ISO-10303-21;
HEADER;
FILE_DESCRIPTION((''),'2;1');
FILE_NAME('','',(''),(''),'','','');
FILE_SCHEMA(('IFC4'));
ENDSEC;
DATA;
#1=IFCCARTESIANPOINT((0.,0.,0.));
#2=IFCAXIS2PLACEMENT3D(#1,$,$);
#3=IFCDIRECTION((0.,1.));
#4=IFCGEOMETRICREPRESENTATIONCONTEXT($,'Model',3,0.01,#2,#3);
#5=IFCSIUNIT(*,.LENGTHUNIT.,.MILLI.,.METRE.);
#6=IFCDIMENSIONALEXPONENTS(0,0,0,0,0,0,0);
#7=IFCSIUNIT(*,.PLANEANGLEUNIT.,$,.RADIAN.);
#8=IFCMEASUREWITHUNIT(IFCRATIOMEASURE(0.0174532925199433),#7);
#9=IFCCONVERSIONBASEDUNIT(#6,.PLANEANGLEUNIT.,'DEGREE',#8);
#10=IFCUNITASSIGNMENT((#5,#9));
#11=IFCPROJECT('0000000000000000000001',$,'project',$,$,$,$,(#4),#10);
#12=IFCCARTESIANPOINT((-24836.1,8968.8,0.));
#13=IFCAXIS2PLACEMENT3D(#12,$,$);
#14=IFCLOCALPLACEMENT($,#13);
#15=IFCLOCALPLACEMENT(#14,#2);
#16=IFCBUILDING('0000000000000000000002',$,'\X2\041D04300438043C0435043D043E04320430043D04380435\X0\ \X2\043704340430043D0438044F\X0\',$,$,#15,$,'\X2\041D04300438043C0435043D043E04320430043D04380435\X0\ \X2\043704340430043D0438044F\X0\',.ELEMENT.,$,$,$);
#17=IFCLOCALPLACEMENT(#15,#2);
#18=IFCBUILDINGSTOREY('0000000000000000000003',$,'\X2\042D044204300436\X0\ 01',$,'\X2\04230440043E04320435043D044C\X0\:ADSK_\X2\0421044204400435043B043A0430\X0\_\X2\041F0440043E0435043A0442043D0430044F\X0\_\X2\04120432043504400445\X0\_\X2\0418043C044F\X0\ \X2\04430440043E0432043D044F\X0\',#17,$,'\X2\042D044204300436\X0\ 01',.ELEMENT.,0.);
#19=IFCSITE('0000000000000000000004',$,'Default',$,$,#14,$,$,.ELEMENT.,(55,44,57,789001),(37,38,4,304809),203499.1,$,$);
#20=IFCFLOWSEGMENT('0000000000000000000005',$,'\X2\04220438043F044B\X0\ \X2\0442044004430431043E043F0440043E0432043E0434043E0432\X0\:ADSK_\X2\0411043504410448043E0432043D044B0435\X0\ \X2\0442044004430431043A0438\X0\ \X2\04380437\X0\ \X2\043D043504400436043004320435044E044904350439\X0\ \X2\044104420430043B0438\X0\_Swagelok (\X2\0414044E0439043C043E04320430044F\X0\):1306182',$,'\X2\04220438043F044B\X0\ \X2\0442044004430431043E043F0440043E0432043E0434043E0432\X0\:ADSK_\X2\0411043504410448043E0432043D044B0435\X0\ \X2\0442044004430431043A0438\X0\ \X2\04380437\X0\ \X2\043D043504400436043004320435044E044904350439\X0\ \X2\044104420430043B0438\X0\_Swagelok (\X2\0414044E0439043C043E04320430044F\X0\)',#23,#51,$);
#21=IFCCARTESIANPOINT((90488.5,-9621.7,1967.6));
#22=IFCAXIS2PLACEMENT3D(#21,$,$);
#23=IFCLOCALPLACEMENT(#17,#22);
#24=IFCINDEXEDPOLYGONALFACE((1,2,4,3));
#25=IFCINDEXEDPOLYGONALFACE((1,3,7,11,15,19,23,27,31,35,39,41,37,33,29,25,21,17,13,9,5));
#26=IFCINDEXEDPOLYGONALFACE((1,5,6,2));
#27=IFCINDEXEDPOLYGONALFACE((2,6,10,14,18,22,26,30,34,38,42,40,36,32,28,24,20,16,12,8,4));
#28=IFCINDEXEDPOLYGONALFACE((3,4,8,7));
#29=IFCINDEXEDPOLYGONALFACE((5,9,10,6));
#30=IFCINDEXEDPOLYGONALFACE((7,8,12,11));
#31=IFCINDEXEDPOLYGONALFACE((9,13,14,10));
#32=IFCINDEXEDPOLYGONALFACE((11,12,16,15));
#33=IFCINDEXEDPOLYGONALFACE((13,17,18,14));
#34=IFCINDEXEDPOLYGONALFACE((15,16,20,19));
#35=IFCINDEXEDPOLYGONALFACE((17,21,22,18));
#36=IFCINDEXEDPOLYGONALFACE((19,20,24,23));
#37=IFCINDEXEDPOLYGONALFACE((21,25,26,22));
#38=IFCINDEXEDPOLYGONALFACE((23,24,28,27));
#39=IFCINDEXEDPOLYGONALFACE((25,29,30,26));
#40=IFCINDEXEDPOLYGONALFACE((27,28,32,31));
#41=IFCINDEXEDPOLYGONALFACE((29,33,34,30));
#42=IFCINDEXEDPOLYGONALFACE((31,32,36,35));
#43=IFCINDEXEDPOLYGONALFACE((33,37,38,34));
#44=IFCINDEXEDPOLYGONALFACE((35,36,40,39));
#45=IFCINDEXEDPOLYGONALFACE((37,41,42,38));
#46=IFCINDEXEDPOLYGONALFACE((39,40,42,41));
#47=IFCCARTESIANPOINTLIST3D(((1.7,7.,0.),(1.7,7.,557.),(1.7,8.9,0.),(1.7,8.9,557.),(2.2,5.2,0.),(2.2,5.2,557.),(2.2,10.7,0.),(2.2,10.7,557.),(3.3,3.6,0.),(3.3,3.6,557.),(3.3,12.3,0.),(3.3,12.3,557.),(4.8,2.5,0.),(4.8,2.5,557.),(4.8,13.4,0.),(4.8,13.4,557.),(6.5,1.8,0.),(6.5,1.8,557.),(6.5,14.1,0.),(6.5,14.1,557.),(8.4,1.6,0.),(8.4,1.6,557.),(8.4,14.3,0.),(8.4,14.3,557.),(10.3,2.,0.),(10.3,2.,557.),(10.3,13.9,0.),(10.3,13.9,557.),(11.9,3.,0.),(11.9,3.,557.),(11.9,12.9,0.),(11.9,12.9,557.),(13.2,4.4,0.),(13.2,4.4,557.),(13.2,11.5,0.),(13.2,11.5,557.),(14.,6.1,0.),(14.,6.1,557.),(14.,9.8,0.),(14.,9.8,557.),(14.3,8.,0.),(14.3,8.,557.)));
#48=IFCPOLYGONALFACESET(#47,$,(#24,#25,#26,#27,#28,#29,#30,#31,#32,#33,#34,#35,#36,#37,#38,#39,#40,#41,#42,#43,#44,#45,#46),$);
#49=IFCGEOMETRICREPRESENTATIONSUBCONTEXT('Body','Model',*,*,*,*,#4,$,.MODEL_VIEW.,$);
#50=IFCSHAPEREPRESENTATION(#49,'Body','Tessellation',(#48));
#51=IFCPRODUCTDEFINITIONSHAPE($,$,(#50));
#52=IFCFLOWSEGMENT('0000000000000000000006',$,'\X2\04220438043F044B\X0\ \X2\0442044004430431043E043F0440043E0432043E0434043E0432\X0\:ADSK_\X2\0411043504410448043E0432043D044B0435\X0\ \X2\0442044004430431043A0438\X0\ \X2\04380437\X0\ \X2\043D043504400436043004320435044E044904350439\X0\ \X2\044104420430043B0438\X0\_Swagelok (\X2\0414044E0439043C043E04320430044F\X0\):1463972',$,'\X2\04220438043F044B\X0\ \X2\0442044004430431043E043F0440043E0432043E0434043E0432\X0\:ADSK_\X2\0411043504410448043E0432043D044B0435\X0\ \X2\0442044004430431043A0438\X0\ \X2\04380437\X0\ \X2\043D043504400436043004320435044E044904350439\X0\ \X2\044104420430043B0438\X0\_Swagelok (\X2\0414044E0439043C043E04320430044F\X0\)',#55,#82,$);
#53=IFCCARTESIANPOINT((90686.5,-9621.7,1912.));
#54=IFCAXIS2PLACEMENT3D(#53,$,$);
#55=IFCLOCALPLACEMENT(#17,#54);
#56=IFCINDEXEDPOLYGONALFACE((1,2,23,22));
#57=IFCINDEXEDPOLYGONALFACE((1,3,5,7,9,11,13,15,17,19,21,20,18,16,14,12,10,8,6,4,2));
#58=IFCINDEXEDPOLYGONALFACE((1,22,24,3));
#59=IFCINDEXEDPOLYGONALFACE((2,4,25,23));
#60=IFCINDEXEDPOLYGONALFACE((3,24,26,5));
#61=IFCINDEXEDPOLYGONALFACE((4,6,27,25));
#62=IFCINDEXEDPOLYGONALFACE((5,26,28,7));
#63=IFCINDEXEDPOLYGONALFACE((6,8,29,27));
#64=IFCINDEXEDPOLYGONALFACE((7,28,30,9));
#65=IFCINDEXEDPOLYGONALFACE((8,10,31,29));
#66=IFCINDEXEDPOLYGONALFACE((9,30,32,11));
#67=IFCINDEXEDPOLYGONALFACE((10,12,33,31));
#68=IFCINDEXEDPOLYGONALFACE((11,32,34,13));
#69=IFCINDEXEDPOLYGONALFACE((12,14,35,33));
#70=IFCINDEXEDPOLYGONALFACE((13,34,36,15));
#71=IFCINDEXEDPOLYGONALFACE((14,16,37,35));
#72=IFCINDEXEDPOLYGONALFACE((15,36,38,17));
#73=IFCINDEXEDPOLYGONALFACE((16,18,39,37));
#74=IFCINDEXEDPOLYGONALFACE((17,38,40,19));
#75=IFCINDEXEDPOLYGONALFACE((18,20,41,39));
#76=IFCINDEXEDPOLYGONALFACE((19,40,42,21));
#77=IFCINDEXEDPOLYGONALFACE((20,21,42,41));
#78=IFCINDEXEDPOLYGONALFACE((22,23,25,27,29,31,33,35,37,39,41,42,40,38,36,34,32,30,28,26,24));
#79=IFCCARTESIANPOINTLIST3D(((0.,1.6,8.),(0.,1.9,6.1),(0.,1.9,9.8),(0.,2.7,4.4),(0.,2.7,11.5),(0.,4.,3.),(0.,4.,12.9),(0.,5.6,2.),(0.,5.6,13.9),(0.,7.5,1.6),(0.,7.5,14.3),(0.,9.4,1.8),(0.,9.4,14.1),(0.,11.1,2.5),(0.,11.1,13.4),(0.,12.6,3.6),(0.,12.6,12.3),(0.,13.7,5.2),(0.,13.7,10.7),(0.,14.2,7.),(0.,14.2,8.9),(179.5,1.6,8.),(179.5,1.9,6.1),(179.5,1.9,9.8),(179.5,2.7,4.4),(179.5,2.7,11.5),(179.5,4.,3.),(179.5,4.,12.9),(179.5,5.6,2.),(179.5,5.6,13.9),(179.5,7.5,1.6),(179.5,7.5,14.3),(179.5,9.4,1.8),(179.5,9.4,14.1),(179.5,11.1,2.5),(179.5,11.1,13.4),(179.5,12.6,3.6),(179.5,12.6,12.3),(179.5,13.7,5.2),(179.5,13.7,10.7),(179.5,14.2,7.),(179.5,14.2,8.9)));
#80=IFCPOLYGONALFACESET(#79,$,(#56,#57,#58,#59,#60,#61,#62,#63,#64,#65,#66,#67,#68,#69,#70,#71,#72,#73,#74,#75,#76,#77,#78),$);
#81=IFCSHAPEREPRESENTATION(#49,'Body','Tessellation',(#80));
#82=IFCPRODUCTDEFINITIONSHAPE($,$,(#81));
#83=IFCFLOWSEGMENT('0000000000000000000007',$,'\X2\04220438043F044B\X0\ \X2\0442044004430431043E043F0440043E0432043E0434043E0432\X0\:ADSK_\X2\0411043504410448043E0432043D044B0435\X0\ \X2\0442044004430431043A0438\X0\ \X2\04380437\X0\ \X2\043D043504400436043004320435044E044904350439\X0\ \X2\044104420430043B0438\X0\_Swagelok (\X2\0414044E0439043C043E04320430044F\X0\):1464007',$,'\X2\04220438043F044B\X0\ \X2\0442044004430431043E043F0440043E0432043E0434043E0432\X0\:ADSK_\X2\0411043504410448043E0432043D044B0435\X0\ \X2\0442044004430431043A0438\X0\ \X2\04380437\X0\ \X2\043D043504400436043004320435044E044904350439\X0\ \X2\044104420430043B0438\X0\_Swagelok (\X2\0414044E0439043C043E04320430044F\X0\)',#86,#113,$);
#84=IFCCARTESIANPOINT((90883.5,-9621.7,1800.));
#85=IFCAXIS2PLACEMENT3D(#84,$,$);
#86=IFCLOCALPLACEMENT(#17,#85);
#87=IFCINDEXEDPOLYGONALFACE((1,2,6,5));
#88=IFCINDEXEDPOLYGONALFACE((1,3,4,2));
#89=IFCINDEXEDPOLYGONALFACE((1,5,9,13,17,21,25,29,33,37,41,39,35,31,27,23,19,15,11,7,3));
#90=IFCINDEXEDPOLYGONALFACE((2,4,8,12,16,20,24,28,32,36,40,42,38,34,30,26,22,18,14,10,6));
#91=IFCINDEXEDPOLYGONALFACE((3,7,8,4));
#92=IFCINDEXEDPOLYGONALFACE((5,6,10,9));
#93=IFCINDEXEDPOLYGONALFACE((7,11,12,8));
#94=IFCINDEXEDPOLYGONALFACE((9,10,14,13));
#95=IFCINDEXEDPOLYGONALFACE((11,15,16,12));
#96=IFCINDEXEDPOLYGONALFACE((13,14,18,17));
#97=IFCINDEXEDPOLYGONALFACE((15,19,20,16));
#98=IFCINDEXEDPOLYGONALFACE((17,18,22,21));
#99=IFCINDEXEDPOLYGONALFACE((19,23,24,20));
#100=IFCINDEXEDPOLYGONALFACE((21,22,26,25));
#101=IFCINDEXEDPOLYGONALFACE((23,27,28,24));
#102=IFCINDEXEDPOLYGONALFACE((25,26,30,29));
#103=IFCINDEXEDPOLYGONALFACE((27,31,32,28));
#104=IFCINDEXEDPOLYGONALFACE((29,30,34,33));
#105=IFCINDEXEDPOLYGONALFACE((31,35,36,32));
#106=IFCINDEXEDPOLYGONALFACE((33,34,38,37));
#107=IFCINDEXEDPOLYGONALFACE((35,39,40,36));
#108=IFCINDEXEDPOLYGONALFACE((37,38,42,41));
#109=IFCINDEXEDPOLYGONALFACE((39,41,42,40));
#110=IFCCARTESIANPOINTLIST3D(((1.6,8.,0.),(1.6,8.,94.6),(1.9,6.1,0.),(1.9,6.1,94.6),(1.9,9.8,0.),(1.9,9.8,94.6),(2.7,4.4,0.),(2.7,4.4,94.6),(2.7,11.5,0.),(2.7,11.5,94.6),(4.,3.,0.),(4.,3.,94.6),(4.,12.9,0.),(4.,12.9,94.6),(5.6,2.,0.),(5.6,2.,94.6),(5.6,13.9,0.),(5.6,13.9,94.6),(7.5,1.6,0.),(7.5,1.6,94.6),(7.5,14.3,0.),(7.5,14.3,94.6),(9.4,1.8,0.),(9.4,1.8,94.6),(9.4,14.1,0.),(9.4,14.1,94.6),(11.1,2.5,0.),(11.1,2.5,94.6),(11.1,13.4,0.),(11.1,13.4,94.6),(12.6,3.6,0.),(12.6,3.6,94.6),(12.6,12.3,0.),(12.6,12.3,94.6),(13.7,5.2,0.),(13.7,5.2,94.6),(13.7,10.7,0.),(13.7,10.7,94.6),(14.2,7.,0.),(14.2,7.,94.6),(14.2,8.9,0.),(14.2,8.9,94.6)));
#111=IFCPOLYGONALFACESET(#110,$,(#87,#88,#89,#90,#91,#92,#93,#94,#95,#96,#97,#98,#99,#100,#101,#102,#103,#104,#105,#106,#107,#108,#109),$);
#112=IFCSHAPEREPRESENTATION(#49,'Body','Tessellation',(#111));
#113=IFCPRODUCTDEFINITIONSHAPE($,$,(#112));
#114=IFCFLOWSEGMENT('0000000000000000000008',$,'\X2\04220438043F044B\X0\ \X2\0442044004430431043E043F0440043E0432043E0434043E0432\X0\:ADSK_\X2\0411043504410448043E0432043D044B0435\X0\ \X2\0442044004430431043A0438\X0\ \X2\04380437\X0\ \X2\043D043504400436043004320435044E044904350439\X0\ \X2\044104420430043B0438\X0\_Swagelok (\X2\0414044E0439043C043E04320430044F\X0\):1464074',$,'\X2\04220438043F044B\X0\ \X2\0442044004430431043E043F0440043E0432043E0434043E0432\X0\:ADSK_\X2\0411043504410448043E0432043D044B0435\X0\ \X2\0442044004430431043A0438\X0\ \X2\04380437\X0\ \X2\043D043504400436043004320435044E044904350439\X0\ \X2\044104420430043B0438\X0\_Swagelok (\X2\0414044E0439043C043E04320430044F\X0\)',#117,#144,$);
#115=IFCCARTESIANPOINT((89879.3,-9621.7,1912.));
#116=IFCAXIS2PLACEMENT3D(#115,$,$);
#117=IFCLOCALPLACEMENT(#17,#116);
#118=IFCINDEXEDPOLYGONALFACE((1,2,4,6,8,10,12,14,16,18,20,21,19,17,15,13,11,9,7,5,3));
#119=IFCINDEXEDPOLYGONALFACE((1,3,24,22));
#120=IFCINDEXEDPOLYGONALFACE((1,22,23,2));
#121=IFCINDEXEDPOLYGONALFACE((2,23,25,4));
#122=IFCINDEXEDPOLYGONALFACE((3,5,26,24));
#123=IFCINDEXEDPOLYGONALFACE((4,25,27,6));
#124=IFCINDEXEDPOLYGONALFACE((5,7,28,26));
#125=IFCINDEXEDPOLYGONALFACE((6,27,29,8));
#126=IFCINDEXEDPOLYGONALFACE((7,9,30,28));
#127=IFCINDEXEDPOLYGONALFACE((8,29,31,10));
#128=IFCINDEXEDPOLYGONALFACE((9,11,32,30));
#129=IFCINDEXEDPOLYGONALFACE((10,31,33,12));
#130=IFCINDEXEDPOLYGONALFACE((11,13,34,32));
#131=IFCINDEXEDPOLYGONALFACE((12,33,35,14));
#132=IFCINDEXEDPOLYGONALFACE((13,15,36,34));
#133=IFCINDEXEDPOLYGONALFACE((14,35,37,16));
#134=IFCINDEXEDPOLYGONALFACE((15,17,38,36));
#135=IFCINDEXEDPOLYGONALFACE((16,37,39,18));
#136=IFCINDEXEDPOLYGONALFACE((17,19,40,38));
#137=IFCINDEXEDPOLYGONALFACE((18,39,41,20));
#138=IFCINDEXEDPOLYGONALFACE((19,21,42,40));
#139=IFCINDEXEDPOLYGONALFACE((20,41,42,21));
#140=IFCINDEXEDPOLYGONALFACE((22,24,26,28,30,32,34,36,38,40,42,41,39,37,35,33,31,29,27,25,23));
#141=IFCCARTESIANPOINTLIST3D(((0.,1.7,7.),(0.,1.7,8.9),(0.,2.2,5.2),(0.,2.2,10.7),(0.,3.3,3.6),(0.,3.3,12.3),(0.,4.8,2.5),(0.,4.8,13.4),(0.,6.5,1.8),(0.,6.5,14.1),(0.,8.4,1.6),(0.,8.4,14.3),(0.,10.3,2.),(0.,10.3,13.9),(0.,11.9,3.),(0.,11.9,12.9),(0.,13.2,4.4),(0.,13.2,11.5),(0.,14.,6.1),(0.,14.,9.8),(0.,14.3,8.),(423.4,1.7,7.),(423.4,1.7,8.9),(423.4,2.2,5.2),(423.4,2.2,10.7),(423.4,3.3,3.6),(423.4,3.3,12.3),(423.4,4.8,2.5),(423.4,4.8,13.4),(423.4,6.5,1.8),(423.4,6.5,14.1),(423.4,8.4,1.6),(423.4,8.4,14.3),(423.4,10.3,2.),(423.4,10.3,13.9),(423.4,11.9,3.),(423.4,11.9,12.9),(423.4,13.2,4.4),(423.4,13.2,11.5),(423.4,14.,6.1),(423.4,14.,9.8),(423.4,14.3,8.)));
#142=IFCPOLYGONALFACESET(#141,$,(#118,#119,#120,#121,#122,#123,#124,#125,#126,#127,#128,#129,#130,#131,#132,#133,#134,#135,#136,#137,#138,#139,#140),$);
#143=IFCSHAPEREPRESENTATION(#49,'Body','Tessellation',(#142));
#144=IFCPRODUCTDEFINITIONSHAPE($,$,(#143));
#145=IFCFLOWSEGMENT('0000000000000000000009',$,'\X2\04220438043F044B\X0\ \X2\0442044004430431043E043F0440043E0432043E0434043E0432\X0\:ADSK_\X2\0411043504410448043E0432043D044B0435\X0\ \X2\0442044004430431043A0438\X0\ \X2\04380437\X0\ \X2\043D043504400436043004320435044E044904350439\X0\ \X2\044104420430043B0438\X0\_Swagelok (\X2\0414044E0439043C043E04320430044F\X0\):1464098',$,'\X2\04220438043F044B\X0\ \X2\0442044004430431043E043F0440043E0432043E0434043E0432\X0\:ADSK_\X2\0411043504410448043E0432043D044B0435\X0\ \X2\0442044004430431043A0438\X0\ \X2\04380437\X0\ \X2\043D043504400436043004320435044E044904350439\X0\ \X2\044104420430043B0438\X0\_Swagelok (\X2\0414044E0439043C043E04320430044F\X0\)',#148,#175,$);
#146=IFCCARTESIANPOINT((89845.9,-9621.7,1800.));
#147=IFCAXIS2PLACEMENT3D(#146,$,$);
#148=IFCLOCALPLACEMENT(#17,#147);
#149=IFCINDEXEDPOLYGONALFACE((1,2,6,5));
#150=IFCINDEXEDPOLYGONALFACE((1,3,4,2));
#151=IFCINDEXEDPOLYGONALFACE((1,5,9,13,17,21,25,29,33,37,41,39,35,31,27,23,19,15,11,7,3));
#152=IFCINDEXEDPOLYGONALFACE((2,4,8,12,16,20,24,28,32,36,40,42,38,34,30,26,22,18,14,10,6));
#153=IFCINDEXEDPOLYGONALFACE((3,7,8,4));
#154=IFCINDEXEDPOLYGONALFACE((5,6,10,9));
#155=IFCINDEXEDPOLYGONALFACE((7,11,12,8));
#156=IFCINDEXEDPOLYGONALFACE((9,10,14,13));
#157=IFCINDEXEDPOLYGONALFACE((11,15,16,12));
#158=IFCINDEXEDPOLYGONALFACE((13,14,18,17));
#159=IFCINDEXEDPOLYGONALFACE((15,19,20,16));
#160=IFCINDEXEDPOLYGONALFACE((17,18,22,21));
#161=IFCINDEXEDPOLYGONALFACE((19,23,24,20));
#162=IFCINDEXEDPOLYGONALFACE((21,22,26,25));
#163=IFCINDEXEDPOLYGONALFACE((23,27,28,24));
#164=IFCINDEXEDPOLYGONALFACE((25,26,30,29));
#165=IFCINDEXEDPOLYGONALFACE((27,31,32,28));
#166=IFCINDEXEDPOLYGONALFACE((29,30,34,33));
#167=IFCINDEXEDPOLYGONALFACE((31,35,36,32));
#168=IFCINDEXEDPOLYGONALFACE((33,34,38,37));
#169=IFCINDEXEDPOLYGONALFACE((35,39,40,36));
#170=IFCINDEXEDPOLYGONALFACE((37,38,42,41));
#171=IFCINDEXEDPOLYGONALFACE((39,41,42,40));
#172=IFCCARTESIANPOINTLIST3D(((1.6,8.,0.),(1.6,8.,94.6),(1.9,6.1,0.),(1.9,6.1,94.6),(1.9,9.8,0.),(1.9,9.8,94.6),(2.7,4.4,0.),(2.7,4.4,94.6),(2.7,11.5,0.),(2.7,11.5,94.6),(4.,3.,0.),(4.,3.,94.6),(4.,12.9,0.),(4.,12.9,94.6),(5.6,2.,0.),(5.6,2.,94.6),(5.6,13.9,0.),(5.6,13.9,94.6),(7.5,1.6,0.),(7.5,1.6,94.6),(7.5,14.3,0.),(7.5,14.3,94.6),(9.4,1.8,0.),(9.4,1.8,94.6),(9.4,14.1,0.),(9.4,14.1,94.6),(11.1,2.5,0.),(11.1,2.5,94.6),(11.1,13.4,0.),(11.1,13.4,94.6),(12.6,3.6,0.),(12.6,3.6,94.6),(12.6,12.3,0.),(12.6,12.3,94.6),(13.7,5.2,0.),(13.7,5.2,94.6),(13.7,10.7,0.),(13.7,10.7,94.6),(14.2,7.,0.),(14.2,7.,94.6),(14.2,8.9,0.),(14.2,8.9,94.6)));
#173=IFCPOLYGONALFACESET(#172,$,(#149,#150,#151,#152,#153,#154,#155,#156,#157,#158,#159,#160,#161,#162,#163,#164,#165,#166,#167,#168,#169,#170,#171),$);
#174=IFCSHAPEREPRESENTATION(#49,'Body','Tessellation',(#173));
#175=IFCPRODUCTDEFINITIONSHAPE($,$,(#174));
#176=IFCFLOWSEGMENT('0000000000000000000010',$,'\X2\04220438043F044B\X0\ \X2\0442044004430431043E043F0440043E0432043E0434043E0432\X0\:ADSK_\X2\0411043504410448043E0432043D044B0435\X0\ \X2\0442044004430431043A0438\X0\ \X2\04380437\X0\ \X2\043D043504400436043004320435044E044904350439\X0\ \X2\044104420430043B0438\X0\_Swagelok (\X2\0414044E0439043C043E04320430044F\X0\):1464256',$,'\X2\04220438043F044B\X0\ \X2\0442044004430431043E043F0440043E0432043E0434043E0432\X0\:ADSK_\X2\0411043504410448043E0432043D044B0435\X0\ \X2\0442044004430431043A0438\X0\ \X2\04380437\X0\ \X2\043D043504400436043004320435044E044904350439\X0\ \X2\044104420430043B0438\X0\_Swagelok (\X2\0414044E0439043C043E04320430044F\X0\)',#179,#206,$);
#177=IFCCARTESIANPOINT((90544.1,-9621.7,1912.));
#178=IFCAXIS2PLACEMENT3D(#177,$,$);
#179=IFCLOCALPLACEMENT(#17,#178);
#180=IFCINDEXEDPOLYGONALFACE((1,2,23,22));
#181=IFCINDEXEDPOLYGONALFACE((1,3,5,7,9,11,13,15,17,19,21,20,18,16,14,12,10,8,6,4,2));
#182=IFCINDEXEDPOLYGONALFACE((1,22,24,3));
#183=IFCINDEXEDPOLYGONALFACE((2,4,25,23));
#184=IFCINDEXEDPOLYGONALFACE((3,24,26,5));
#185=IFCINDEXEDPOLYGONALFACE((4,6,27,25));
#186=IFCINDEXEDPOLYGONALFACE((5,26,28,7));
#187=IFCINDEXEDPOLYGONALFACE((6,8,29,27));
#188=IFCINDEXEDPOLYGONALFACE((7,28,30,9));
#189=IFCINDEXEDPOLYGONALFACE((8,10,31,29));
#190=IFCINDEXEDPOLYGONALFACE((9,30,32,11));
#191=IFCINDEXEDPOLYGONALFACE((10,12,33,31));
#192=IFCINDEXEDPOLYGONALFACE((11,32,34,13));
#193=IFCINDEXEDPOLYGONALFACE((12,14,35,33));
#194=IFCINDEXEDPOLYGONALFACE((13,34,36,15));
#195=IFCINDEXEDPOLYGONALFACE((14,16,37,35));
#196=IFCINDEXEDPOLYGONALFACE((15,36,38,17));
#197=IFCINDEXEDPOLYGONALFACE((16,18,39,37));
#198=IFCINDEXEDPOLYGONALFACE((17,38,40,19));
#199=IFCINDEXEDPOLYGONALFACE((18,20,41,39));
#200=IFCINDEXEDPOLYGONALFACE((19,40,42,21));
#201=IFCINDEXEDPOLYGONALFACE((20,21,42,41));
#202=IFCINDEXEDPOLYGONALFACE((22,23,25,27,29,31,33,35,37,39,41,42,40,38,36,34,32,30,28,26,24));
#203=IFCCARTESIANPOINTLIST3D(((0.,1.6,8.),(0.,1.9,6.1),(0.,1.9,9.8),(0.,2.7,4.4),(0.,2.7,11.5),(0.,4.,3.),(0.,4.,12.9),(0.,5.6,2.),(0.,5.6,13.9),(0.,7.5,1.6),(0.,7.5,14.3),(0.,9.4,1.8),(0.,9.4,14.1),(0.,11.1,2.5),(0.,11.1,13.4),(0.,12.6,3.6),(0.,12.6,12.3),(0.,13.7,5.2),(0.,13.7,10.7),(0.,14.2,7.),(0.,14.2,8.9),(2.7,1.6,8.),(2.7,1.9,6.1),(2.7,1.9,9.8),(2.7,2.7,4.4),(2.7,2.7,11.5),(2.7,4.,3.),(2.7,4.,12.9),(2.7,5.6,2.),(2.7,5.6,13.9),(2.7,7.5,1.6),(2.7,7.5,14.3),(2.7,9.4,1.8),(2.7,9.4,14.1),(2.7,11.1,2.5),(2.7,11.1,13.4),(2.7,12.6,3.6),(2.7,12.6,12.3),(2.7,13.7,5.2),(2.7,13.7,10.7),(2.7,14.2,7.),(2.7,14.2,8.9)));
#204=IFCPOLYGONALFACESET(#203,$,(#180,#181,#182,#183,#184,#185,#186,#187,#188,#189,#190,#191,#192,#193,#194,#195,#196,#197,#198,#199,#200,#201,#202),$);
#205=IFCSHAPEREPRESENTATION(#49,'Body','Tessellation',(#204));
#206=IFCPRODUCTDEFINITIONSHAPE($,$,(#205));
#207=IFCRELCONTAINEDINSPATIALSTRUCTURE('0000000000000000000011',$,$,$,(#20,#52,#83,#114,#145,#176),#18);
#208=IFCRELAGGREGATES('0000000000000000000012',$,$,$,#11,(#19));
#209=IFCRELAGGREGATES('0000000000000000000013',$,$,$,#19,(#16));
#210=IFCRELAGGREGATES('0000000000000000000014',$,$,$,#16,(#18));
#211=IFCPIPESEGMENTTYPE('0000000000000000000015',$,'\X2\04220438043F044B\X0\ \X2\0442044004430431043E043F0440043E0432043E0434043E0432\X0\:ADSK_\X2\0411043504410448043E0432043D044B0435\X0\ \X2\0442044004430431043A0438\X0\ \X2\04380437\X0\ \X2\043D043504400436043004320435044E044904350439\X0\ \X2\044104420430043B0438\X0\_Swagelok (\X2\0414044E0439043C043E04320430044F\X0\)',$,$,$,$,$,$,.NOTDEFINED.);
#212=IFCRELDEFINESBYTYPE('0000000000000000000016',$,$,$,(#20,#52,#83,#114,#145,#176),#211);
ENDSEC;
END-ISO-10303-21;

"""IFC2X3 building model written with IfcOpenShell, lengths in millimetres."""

from ifc_helpers import new_model, entity, si_unit, converted_unit, direction, frame, origin, origin_2d_with_axis, place, context, subcontext, project, spatial, circle, extrude, type_object, element, save


model = new_model("IFC2X3")

# Units and contexts
model_context = context("Model", 3, precision=0.01, world=origin(), true_north=direction((0.0, 1.0)))
body_context = subcontext(model_context, "Body", "Model", "MODEL_VIEW")
ifc_project = project(units=[si_unit("LENGTHUNIT", "METRE", prefix="MILLI"), converted_unit("PLANEANGLEUNIT", "DEGREE", entity("IfcRatioMeasure", 0.0174532925199433), si_unit("PLANEANGLEUNIT", "RADIAN"), dimensions=[0, 0, 0, 0, 0, 0, 0])], contexts=[model_context])

# Site, building, storey
site_placement = place(None, frame((-24836.1, 8968.8, 0.0)))
site = spatial("IfcSite", under=ifc_project, at=site_placement, Name="Default", CompositionType="ELEMENT", RefLatitude=(55, 44, 57, 789001), RefLongitude=(37, 38, 4, 304809), RefElevation=203499.1)
building_placement = place(site_placement, origin())
building = spatial("IfcBuilding", under=site, at=building_placement, Name="Наименование здания", LongName="Наименование здания", CompositionType="ELEMENT")
storey_placement = place(building_placement, origin())
storey = spatial("IfcBuildingStorey", under=building, at=storey_placement, Name="Этаж 01", ObjectType="Уровень:ADSK_Стрелка_Проектная_Вверх_Имя уровня", LongName="Этаж 01", CompositionType="ELEMENT", Elevation=0.0)

# Flow segments
pipe_segment_type_1 = type_object("IfcPipeSegmentType", Name="Типы трубопроводов:ADSK_Бесшовные трубки из нержавеющей стали_Swagelok (Дюймовая)", PredefinedType="NOTDEFINED")
flow_segment_1_placement = place(storey_placement, frame((90488.5, -9621.7, 1967.6)))
element("IfcFlowSegment", 1, at=flow_segment_1_placement, inside=storey, type_object=pipe_segment_type_1, Name="Типы трубопроводов:ADSK_Бесшовные трубки из нержавеющей стали_Swagelok (Дюймовая):1306182", ObjectType="Типы трубопроводов:ADSK_Бесшовные трубки из нержавеющей стали_Swagelok (Дюймовая)", context=body_context, shape_type="SweptSolid", body=[
    extrude(circle(Radius=6.3, at=origin_2d_with_axis()), frame((8.0, 8.0, 0.0)), (0.0, 0.0, 1.0), 557.0),
])
flow_segment_2_placement = place(storey_placement, frame((90686.5, -9621.7, 1912.0)))
element("IfcFlowSegment", 2, at=flow_segment_2_placement, inside=storey, type_object=pipe_segment_type_1, Name="Типы трубопроводов:ADSK_Бесшовные трубки из нержавеющей стали_Swagelok (Дюймовая):1463972", ObjectType="Типы трубопроводов:ADSK_Бесшовные трубки из нержавеющей стали_Swagelok (Дюймовая)", context=body_context, shape_type="SweptSolid", body=[
    extrude(circle(Radius=6.3, at=origin_2d_with_axis()), frame((0.0, 8.0, 8.0), z_axis=(1.0, 0.0, 0.0), x_axis=(0.0, -1.0, 0.0)), (0.0, 0.0, 1.0), 179.5),
])
flow_segment_3_placement = place(storey_placement, frame((90883.5, -9621.7, 1800.0)))
element("IfcFlowSegment", 3, at=flow_segment_3_placement, inside=storey, type_object=pipe_segment_type_1, Name="Типы трубопроводов:ADSK_Бесшовные трубки из нержавеющей стали_Swagelok (Дюймовая):1464007", ObjectType="Типы трубопроводов:ADSK_Бесшовные трубки из нержавеющей стали_Swagelok (Дюймовая)", context=body_context, shape_type="SweptSolid", body=[
    extrude(circle(Radius=6.3, at=origin_2d_with_axis()), frame((8.0, 8.0, 0.0), z_axis=(0.0, 0.0, 1.0), x_axis=(-1.0, 0.0, 0.0)), (0.0, 0.0, 1.0), 94.6),
])
flow_segment_4_placement = place(storey_placement, frame((89879.3, -9621.7, 1912.0)))
element("IfcFlowSegment", 4, at=flow_segment_4_placement, inside=storey, type_object=pipe_segment_type_1, Name="Типы трубопроводов:ADSK_Бесшовные трубки из нержавеющей стали_Swagelok (Дюймовая):1464074", ObjectType="Типы трубопроводов:ADSK_Бесшовные трубки из нержавеющей стали_Swagelok (Дюймовая)", context=body_context, shape_type="SweptSolid", body=[
    extrude(circle(Radius=6.3, at=origin_2d_with_axis()), frame((0.0, 8.0, 8.0), z_axis=(1.0, 0.0, 0.0), x_axis=(0.0, 1.0, 0.0)), (0.0, 0.0, 1.0), 423.4),
])
flow_segment_5_placement = place(storey_placement, frame((89845.9, -9621.7, 1800.0)))
element("IfcFlowSegment", 5, at=flow_segment_5_placement, inside=storey, type_object=pipe_segment_type_1, Name="Типы трубопроводов:ADSK_Бесшовные трубки из нержавеющей стали_Swagelok (Дюймовая):1464098", ObjectType="Типы трубопроводов:ADSK_Бесшовные трубки из нержавеющей стали_Swagelok (Дюймовая)", context=body_context, shape_type="SweptSolid", body=[
    extrude(circle(Radius=6.3, at=origin_2d_with_axis()), frame((8.0, 8.0, 0.0), z_axis=(0.0, 0.0, 1.0), x_axis=(-1.0, 0.0, 0.0)), (0.0, 0.0, 1.0), 94.6),
])
flow_segment_6_placement = place(storey_placement, frame((90544.1, -9621.7, 1912.0)))
element("IfcFlowSegment", 6, at=flow_segment_6_placement, inside=storey, type_object=pipe_segment_type_1, Name="Типы трубопроводов:ADSK_Бесшовные трубки из нержавеющей стали_Swagelok (Дюймовая):1464256", ObjectType="Типы трубопроводов:ADSK_Бесшовные трубки из нержавеющей стали_Swagelok (Дюймовая)", context=body_context, shape_type="SweptSolid", body=[
    extrude(circle(Radius=6.3, at=origin_2d_with_axis()), frame((0.0, 8.0, 8.0), z_axis=(1.0, 0.0, 0.0), x_axis=(0.0, -1.0, 0.0)), (0.0, 0.0, 1.0), 2.7),
])

save(model, "model.ifc")
